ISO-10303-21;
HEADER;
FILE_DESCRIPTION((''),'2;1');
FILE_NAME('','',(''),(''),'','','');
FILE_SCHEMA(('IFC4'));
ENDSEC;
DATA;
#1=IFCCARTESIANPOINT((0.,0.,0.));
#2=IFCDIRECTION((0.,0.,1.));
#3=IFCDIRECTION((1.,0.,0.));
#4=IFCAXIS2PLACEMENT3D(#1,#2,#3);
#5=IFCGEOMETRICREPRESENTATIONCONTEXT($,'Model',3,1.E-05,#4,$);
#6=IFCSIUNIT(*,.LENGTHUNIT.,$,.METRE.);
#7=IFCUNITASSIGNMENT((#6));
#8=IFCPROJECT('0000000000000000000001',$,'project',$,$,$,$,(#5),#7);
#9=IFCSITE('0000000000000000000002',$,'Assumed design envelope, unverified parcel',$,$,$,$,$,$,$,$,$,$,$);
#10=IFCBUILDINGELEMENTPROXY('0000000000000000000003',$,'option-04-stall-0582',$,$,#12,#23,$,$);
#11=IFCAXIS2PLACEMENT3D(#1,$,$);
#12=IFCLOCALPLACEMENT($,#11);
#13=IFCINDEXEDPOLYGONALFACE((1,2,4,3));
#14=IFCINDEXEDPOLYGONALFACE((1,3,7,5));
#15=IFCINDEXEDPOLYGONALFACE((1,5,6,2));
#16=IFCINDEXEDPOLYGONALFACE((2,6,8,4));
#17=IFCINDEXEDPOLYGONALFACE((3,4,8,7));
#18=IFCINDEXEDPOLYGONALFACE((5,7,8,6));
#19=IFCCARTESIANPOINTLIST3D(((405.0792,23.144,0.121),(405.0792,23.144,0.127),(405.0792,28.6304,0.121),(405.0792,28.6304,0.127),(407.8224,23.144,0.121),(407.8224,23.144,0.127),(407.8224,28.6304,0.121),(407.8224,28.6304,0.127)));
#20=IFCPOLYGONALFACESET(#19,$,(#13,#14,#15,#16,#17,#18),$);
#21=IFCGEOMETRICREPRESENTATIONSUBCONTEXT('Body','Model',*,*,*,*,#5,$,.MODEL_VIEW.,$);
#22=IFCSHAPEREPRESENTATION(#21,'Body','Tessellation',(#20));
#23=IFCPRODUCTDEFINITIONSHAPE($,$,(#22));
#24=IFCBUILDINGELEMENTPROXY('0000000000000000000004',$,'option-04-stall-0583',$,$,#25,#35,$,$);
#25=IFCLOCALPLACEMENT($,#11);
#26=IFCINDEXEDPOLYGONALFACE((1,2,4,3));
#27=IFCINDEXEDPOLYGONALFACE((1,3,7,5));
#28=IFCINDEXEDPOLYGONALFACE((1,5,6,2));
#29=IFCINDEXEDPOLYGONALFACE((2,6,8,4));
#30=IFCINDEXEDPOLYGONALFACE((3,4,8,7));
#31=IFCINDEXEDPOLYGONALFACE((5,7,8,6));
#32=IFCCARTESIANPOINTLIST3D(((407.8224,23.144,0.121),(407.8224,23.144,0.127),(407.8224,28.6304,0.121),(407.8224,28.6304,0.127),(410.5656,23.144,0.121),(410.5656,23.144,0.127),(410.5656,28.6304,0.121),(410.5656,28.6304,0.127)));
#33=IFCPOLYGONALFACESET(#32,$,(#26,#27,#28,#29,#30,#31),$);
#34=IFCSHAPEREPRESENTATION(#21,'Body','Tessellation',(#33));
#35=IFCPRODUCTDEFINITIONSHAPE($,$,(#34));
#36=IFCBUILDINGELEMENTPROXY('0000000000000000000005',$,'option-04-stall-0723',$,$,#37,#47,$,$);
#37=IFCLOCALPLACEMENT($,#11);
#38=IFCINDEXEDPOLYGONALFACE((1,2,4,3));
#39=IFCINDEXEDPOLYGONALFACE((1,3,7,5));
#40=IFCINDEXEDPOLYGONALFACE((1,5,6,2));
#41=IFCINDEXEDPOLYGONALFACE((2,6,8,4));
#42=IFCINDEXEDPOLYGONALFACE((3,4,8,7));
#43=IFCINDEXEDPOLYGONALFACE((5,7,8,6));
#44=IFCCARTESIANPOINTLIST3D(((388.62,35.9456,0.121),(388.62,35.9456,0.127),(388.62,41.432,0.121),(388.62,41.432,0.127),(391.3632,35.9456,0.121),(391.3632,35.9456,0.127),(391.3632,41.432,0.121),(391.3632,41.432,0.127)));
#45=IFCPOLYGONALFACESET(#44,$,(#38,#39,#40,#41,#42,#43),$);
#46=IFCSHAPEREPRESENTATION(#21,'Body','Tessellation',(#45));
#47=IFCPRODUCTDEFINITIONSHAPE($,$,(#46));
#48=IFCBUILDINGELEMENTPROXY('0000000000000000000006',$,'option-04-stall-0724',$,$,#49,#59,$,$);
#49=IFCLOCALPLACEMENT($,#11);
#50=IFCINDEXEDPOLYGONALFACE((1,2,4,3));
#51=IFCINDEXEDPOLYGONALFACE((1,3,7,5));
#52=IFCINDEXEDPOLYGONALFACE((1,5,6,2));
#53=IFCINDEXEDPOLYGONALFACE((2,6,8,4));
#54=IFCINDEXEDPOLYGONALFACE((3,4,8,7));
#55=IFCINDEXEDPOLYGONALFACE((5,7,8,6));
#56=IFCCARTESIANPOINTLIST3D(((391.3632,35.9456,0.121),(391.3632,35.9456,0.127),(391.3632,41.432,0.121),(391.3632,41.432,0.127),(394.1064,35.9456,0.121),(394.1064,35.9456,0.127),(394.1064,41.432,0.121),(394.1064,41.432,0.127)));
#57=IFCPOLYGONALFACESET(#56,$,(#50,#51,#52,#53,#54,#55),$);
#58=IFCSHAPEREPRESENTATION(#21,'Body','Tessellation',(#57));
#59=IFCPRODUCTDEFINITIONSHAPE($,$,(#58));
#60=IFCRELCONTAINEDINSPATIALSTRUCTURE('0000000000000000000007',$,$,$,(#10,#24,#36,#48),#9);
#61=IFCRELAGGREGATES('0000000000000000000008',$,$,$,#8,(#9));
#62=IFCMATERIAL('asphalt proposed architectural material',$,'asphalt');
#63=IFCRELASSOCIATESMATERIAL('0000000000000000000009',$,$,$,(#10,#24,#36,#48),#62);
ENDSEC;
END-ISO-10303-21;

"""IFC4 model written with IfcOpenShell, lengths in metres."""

from ifc_helpers import new_model, si_unit, frame, origin_with_axes, place, context, subcontext, project, spatial, rectangle, extrude, material, element, save


model = new_model("IFC4")

# Units and contexts
model_context = context("Model", 3, precision=1e-05, world=origin_with_axes())
body_context = subcontext(model_context, "Body", "Model", "MODEL_VIEW")
ifc_project = project(units=[si_unit("LENGTHUNIT", "METRE")], contexts=[model_context])

# Site
site = spatial("IfcSite", under=ifc_project, Name="Assumed design envelope, unverified parcel")

# Building element proxies
ifc_material = material(Name="asphalt proposed architectural material", Category="asphalt")
for number, where, z_axis, x_axis, name in (
    (1, (406.4508, 25.8872, 0.121), (0.0, 0.0, 1.0), (1.0, 0.0, 0.0), "option-04-stall-0582"),
    (2, (409.194, 25.8872, 0.121), (0.0, 0.0, 1.0), (1.0, 0.0, 0.0), "option-04-stall-0583"),
):
    element("IfcBuildingElementProxy", number, at=place(None, frame(where, z_axis=z_axis, x_axis=x_axis)), inside=site, material=ifc_material, Name=name, context=body_context, shape_type="SweptSolid", body=[
        extrude(rectangle(XDim=2.7432, YDim=5.4864), origin_with_axes(), (0.0, 0.0, 1.0), 0.006),
    ])
for number, where, z_axis, x_axis, name in (
    (3, (389.9916, 38.6888, 0.121), (0.0, 0.0, 1.0), (1.0, 0.0, 0.0), "option-04-stall-0723"),
    (4, (392.7348, 38.6888, 0.121), (0.0, 0.0, 1.0), (1.0, 0.0, 0.0), "option-04-stall-0724"),
):
    element("IfcBuildingElementProxy", number, at=place(None, frame(where, z_axis=z_axis, x_axis=x_axis)), inside=site, material=ifc_material, Name=name, context=body_context, shape_type="SweptSolid", body=[
        extrude(rectangle(XDim=2.7432, YDim=5.4864), origin_with_axes(), (0.0, 0.0, 1.0), 0.006),
    ])

save(model, "model.ifc")
